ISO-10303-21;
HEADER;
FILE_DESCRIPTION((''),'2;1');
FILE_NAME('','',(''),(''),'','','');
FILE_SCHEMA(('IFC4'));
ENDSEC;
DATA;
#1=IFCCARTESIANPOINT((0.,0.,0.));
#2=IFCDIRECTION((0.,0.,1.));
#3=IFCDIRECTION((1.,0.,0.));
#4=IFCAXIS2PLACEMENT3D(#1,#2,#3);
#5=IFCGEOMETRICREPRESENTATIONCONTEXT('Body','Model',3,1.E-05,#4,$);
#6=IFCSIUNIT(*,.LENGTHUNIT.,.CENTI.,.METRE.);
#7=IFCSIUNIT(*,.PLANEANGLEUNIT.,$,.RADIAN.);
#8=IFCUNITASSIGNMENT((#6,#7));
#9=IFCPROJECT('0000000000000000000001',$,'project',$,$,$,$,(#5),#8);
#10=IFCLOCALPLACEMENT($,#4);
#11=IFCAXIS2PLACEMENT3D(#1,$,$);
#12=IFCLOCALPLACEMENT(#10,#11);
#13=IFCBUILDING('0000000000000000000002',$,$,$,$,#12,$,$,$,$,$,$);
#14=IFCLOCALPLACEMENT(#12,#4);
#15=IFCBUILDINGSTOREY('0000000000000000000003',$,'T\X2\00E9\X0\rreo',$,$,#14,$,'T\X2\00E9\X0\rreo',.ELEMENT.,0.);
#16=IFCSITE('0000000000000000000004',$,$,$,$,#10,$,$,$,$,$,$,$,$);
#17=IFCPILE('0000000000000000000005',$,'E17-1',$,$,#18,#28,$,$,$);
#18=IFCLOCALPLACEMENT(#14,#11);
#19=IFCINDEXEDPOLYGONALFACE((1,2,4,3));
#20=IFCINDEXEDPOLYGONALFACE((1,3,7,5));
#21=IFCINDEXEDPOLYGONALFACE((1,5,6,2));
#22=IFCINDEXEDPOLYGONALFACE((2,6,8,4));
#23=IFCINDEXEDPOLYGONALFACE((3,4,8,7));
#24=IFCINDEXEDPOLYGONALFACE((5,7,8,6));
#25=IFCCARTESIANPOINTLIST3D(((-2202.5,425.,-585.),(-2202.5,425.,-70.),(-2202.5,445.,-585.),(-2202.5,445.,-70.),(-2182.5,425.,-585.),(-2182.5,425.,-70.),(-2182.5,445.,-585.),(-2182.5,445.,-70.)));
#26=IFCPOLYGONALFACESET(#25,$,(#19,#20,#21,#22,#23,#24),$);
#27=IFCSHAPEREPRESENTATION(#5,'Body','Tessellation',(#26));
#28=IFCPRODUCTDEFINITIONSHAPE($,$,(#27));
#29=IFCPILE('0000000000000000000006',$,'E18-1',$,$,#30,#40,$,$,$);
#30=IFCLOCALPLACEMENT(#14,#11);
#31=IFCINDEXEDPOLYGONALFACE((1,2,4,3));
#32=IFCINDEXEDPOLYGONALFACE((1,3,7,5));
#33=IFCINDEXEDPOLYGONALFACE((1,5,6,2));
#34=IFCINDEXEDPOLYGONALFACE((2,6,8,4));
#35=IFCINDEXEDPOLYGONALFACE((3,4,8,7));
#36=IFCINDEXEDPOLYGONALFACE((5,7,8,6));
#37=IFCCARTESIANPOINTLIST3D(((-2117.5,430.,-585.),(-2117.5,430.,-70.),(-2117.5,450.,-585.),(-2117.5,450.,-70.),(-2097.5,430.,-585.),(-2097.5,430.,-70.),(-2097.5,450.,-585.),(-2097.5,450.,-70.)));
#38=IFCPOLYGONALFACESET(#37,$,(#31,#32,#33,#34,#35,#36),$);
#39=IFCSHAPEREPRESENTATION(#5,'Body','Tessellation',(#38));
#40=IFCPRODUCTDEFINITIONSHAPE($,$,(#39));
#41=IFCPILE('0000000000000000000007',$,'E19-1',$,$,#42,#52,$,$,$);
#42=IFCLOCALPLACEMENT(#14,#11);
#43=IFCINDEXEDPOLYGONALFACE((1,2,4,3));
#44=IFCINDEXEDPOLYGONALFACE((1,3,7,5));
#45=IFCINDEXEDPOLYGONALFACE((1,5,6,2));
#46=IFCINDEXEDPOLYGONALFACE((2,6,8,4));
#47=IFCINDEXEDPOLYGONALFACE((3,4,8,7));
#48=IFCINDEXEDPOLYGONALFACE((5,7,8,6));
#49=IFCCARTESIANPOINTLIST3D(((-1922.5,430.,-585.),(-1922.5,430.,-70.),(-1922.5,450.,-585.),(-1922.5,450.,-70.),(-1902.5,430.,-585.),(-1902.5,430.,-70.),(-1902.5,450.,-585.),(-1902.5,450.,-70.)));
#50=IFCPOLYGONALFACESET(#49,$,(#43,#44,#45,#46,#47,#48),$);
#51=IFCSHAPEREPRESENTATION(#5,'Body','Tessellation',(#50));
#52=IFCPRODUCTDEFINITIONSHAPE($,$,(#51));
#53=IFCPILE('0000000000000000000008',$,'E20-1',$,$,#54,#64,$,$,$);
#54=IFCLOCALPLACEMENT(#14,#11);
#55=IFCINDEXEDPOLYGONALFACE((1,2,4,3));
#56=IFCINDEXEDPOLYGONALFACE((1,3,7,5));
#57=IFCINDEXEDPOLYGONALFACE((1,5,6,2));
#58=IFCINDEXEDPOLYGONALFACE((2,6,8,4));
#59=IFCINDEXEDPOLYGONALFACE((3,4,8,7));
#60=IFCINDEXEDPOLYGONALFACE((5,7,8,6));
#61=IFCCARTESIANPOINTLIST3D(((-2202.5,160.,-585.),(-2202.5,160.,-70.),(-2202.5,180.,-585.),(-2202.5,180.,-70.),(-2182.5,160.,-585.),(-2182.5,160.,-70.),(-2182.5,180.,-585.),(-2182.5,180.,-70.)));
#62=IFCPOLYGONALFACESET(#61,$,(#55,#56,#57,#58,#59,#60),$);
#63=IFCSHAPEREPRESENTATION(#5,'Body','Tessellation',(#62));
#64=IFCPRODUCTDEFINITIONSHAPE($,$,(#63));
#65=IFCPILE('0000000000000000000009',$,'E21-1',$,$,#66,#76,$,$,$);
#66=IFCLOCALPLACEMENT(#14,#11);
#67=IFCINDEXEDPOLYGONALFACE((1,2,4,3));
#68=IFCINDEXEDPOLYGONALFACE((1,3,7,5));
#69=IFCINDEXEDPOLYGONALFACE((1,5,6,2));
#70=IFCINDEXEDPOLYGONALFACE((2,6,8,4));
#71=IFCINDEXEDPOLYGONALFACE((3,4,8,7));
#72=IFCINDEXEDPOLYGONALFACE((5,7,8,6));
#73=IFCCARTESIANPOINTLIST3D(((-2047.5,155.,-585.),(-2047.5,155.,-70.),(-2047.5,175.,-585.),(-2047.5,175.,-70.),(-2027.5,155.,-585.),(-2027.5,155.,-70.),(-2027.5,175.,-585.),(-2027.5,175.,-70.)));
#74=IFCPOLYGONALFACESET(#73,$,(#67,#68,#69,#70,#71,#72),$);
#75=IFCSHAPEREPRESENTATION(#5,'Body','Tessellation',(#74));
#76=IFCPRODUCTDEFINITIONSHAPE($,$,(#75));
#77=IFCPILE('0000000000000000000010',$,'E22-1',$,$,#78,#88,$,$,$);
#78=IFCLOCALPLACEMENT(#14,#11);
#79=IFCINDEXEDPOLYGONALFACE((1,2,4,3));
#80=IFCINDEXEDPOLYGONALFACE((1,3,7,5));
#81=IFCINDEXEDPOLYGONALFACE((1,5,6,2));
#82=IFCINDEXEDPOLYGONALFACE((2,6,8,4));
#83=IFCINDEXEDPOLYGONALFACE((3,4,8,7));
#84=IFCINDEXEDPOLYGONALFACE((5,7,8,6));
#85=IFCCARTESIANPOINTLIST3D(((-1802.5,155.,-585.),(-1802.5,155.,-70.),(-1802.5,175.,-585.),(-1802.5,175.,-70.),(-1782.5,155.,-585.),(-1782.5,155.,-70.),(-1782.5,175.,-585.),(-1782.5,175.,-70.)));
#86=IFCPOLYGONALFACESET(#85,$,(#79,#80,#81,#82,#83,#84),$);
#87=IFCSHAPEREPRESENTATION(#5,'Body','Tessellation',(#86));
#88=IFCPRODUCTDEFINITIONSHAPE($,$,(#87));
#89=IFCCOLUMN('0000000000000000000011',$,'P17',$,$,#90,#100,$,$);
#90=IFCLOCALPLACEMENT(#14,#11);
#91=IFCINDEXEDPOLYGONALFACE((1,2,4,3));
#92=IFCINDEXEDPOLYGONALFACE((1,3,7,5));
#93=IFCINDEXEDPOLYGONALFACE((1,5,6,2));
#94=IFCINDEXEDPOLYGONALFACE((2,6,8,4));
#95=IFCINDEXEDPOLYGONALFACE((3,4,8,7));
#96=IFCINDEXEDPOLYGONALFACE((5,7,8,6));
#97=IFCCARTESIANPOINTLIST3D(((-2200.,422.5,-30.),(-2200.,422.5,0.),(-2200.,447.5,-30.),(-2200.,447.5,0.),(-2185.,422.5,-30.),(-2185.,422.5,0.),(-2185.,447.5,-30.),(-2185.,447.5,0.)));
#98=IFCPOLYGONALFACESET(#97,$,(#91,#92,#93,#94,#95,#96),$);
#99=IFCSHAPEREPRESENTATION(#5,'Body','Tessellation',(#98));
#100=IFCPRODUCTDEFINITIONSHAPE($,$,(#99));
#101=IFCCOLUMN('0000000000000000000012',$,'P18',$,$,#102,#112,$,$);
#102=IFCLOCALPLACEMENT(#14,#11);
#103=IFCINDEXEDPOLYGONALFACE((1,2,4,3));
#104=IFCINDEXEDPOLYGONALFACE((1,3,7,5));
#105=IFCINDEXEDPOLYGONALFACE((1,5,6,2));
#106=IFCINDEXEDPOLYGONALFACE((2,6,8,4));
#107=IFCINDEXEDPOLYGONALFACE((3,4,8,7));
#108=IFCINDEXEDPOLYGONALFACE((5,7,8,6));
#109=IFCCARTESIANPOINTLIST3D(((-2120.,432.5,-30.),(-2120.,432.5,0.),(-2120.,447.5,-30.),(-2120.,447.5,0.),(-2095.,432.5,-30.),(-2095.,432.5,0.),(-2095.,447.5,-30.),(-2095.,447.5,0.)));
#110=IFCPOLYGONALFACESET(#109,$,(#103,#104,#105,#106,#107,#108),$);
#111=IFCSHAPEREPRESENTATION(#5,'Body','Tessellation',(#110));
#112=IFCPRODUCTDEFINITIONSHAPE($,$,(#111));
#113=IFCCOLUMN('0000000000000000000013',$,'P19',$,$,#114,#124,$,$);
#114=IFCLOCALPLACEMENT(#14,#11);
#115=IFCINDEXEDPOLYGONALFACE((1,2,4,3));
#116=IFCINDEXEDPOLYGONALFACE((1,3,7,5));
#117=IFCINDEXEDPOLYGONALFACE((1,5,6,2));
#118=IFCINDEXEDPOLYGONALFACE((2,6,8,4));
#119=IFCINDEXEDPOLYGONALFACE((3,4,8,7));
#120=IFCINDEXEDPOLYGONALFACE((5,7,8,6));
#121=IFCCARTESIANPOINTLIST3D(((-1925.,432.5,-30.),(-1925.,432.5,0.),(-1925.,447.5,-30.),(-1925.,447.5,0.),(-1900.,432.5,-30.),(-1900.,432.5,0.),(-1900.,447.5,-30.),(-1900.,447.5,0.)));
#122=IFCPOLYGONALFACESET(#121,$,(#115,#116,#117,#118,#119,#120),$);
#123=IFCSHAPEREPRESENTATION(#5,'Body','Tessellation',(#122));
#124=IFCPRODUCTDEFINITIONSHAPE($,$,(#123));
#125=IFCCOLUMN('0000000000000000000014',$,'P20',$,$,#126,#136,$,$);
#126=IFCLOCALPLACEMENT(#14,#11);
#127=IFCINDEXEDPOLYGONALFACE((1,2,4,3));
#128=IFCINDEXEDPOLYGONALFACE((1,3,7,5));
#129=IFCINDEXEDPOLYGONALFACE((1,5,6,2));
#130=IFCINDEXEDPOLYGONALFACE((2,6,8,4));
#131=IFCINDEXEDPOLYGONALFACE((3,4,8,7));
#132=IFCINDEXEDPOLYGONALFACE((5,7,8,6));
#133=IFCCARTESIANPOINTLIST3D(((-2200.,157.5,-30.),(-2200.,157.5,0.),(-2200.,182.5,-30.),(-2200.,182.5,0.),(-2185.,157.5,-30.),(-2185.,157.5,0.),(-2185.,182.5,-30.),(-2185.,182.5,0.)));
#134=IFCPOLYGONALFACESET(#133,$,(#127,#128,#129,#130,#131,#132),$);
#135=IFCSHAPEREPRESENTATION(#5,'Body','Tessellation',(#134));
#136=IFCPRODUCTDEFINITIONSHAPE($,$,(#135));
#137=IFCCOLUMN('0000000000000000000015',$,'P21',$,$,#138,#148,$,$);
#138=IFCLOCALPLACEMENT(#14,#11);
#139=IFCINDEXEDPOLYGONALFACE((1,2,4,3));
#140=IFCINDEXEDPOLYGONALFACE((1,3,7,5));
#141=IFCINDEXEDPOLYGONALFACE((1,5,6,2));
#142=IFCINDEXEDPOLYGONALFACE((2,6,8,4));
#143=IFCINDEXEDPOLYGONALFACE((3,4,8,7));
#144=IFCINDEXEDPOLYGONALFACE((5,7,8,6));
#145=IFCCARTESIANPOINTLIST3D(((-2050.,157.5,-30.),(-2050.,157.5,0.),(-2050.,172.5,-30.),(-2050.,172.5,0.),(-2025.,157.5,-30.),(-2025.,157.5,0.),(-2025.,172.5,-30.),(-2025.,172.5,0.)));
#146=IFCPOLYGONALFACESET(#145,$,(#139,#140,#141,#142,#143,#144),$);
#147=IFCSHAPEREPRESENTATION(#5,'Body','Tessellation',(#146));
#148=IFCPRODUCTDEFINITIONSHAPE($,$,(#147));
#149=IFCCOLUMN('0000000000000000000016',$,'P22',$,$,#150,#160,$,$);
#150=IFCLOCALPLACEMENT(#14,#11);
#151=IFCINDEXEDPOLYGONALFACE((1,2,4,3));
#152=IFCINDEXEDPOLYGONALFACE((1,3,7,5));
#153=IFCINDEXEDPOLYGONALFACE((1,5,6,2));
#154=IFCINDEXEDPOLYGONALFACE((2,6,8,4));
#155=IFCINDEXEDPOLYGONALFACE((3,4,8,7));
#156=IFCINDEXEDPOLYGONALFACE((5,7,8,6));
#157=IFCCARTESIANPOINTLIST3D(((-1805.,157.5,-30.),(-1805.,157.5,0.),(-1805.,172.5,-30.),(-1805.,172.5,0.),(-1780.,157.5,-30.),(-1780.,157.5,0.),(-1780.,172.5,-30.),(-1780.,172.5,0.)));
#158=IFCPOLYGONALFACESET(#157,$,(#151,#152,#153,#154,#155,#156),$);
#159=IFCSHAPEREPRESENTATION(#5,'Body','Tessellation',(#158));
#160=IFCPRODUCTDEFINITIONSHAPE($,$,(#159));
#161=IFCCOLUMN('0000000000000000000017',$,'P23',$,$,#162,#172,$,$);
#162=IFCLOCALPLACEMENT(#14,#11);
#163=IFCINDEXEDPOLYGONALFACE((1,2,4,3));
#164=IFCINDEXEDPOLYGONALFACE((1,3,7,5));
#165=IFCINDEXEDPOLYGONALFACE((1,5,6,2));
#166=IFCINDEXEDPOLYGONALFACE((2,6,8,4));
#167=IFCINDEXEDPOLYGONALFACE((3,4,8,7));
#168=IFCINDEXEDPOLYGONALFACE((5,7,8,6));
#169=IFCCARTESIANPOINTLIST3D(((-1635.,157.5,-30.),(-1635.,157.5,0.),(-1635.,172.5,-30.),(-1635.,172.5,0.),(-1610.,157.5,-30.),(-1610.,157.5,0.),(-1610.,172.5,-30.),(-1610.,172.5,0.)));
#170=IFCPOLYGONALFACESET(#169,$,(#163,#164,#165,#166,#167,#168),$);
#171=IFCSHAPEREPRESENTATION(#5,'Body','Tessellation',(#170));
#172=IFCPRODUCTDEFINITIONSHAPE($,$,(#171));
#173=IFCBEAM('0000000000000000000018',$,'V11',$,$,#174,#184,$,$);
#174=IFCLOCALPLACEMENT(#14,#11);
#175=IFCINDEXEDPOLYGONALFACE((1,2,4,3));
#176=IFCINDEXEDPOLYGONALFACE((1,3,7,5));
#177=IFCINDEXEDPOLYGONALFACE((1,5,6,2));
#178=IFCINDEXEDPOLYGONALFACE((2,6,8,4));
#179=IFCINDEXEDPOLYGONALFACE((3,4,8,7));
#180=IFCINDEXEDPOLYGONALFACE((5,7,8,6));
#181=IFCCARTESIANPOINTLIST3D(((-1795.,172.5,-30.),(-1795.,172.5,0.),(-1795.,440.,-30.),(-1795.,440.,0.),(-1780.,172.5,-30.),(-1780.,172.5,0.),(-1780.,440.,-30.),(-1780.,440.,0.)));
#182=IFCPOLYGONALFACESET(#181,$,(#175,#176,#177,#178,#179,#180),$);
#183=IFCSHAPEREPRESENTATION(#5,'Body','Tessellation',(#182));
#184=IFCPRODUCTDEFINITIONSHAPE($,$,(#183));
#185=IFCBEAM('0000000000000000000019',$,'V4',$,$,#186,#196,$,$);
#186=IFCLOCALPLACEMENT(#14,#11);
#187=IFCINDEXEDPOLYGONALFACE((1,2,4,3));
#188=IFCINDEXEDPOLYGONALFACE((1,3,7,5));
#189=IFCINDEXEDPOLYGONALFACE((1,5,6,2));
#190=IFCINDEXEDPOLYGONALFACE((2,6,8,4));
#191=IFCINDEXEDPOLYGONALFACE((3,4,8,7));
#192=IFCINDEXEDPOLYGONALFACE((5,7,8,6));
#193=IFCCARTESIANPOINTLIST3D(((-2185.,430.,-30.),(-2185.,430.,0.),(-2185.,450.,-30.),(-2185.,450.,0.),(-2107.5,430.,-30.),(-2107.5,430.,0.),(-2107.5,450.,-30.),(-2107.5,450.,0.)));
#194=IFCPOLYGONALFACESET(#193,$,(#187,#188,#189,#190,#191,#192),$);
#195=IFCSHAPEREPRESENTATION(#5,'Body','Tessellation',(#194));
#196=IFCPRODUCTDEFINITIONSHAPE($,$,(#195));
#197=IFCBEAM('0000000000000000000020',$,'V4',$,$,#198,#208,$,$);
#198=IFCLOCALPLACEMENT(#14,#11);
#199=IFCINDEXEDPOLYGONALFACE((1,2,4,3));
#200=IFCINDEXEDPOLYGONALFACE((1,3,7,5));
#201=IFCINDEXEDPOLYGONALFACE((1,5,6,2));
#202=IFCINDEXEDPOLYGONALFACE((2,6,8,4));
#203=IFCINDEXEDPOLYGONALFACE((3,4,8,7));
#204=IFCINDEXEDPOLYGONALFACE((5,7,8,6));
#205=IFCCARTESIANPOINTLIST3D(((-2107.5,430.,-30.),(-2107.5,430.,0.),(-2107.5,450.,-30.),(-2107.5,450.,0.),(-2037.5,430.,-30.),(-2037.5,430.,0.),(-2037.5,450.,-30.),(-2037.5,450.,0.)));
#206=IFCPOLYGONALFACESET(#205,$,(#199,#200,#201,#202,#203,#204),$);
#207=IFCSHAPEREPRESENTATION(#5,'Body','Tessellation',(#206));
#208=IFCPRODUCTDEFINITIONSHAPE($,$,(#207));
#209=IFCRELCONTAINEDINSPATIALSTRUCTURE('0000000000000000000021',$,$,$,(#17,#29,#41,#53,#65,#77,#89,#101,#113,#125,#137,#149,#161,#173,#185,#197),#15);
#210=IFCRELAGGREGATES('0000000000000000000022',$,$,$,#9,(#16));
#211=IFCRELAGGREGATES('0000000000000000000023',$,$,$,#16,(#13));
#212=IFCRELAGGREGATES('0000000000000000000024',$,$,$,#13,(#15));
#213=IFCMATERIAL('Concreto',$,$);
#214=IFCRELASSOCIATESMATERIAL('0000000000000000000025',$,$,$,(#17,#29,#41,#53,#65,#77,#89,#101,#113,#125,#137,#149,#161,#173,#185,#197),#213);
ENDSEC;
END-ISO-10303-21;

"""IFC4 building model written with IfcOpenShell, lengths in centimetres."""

from ifc_helpers import new_model, si_unit, frame, origin, origin_with_axes, origin_2d_with_axis, place, context, project, spatial, rectangle, extrude, material, element, save


model = new_model("IFC4")

# Units and contexts
model_context = context("Model", 3, precision=1e-05, world=origin_with_axes(), identifier="Body")
ifc_project = project(units=[si_unit("LENGTHUNIT", "METRE", prefix="CENTI"), si_unit("PLANEANGLEUNIT", "RADIAN")], contexts=[model_context])

# Site, building, storey
site_placement = place(None, origin_with_axes())
site = spatial("IfcSite", under=ifc_project, at=site_placement)
building_placement = place(site_placement, origin())
building = spatial("IfcBuilding", under=site, at=building_placement)
storey_placement = place(building_placement, origin_with_axes())
storey = spatial("IfcBuildingStorey", under=building, at=storey_placement, Name="Térreo", LongName="Térreo", CompositionType="ELEMENT", Elevation=0.0)

# Piles
ifc_material = material(Name="Concreto")
pile_1_placement = place(storey_placement, frame((-2192.5, 435.0, -70.0), z_axis=(0.0, 0.0, 1.0), x_axis=(1.0, 0.0, 0.0)))
element("IfcPile", 1, at=pile_1_placement, inside=storey, material=ifc_material, Name="E17-1", context=model_context, shape_type="SweptSolid", body=[
    extrude(rectangle(XDim=20.0, YDim=20.0, at=origin_2d_with_axis()), frame((0.0, 0.0, -515.0), z_axis=(0.0, 0.0, 1.0), x_axis=(-1.0, 0.0, 0.0)), (0.0, 0.0, 1.0), 515.0),
])
for number, where, z_axis, x_axis, name in (
    (2, (-2107.5, 440.0, -70.0), (0.0, 0.0, 1.0), (1.0, 0.0, 0.0), "E18-1"),
    (3, (-1912.5, 440.0, -70.0), (0.0, 0.0, 1.0), (1.0, 0.0, 0.0), "E19-1"),
):
    element("IfcPile", number, at=place(storey_placement, frame(where, z_axis=z_axis, x_axis=x_axis)), inside=storey, material=ifc_material, Name=name, context=model_context, shape_type="SweptSolid", body=[
        extrude(rectangle(XDim=20.0, YDim=20.0, at=origin_2d_with_axis()), frame((0.0, 0.0, -515.0), z_axis=(0.0, 0.0, 1.0), x_axis=(0.0, 1.0, 0.0)), (0.0, 0.0, 1.0), 515.0),
    ])
pile_2_placement = place(storey_placement, frame((-2192.5, 170.0, -70.0), z_axis=(0.0, 0.0, 1.0), x_axis=(1.0, 0.0, 0.0)))
element("IfcPile", 4, at=pile_2_placement, inside=storey, material=ifc_material, Name="E20-1", context=model_context, shape_type="SweptSolid", body=[
    extrude(rectangle(XDim=20.0, YDim=20.0, at=origin_2d_with_axis()), frame((0.0, 0.0, -515.0), z_axis=(0.0, 0.0, 1.0), x_axis=(1.0, 0.0, 0.0)), (0.0, 0.0, 1.0), 515.0),
])
pile_3_placement = place(storey_placement, frame((-2037.5, 165.0, -70.0), z_axis=(0.0, 0.0, 1.0), x_axis=(1.0, 0.0, 0.0)))
element("IfcPile", 5, at=pile_3_placement, inside=storey, material=ifc_material, Name="E21-1", context=model_context, shape_type="SweptSolid", body=[
    extrude(rectangle(XDim=20.0, YDim=20.0, at=origin_2d_with_axis()), frame((0.0, 0.0, -515.0), z_axis=(0.0, 0.0, 1.0), x_axis=(0.0, 1.0, 0.0)), (0.0, 0.0, 1.0), 515.0),
])
pile_4_placement = place(storey_placement, frame((-1792.5, 165.0, -70.0), z_axis=(0.0, 0.0, 1.0), x_axis=(1.0, 0.0, 0.0)))
element("IfcPile", 6, at=pile_4_placement, inside=storey, material=ifc_material, Name="E22-1", context=model_context, shape_type="SweptSolid", body=[
    extrude(rectangle(XDim=20.0, YDim=20.0, at=origin_2d_with_axis()), frame((0.0, 0.0, -515.0), z_axis=(0.0, 0.0, 1.0), x_axis=(0.0, -1.0, 0.0)), (0.0, 0.0, 1.0), 515.0),
])

# Columns
column_1_placement = place(storey_placement, frame((-2192.5, 435.0, 0.0), z_axis=(0.0, 0.0, 1.0), x_axis=(1.0, 0.0, 0.0)))
element("IfcColumn", 7, at=column_1_placement, inside=storey, material=ifc_material, Name="P17", context=model_context, shape_type="SolidModel", body=[
    extrude(rectangle(XDim=15.0, YDim=25.0, at=origin_2d_with_axis()), frame((0.0, 0.0, -30.0), z_axis=(0.0, 0.0, 1.0), x_axis=(-1.0, 0.0, 0.0)), (0.0, 0.0, 1.0), 30.0),
])
for number, where, z_axis, x_axis, name in (
    (8, (-2107.5, 440.0, 0.0), (0.0, 0.0, 1.0), (1.0, 0.0, 0.0), "P18"),
    (9, (-1912.5, 440.0, 0.0), (0.0, 0.0, 1.0), (1.0, 0.0, 0.0), "P19"),
):
    element("IfcColumn", number, at=place(storey_placement, frame(where, z_axis=z_axis, x_axis=x_axis)), inside=storey, material=ifc_material, Name=name, context=model_context, shape_type="SolidModel", body=[
        extrude(rectangle(XDim=15.0, YDim=25.0, at=origin_2d_with_axis()), frame((0.0, 0.0, -30.0), z_axis=(0.0, 0.0, 1.0), x_axis=(0.0, 1.0, 0.0)), (0.0, 0.0, 1.0), 30.0),
    ])
column_2_placement = place(storey_placement, frame((-2192.5, 170.0, 0.0), z_axis=(0.0, 0.0, 1.0), x_axis=(1.0, 0.0, 0.0)))
element("IfcColumn", 10, at=column_2_placement, inside=storey, material=ifc_material, Name="P20", context=model_context, shape_type="SolidModel", body=[
    extrude(rectangle(XDim=15.0, YDim=25.0, at=origin_2d_with_axis()), frame((0.0, 0.0, -30.0), z_axis=(0.0, 0.0, 1.0), x_axis=(1.0, 0.0, 0.0)), (0.0, 0.0, 1.0), 30.0),
])
column_3_placement = place(storey_placement, frame((-2037.5, 165.0, 0.0), z_axis=(0.0, 0.0, 1.0), x_axis=(1.0, 0.0, 0.0)))
element("IfcColumn", 11, at=column_3_placement, inside=storey, material=ifc_material, Name="P21", context=model_context, shape_type="SolidModel", body=[
    extrude(rectangle(XDim=15.0, YDim=25.0, at=origin_2d_with_axis()), frame((0.0, 0.0, -30.0), z_axis=(0.0, 0.0, 1.0), x_axis=(0.0, 1.0, 0.0)), (0.0, 0.0, 1.0), 30.0),
])
column_4_placement = place(storey_placement, frame((-1792.5, 165.0, 0.0), z_axis=(0.0, 0.0, 1.0), x_axis=(1.0, 0.0, 0.0)))
element("IfcColumn", 12, at=column_4_placement, inside=storey, material=ifc_material, Name="P22", context=model_context, shape_type="SolidModel", body=[
    extrude(rectangle(XDim=15.0, YDim=25.0, at=origin_2d_with_axis()), frame((0.0, 0.0, -30.0), z_axis=(0.0, 0.0, 1.0), x_axis=(0.0, -1.0, 0.0)), (0.0, 0.0, 1.0), 30.0),
])
column_5_placement = place(storey_placement, frame((-1622.5, 165.0, 0.0), z_axis=(0.0, 0.0, 1.0), x_axis=(1.0, 0.0, 0.0)))
element("IfcColumn", 13, at=column_5_placement, inside=storey, material=ifc_material, Name="P23", context=model_context, shape_type="SolidModel", body=[
    extrude(rectangle(XDim=15.0, YDim=25.0, at=origin_2d_with_axis()), frame((0.0, 0.0, -30.0), z_axis=(0.0, 0.0, 1.0), x_axis=(0.0, 1.0, 0.0)), (0.0, 0.0, 1.0), 30.0),
])

# Beams
beam_1_placement = place(storey_placement, frame((-1787.5, 306.25, 0.0), z_axis=(0.0, 0.0, 1.0), x_axis=(1.0, 0.0, 0.0)))
element("IfcBeam", 14, at=beam_1_placement, inside=storey, material=ifc_material, Name="V11", context=model_context, shape_type="SolidModel", body=[
    extrude(rectangle(XDim=15.0, YDim=30.0, at=origin_2d_with_axis()), frame((0.0, -133.75, -15.0), z_axis=(0.0, 1.0, 0.0), x_axis=(-1.0, 0.0, 0.0)), (0.0, 0.0, 1.0), 267.5),
])
beam_2_placement = place(storey_placement, frame((-2146.25, 440.0, 0.0), z_axis=(0.0, 0.0, 1.0), x_axis=(1.0, 0.0, 0.0)))
element("IfcBeam", 15, at=beam_2_placement, inside=storey, material=ifc_material, Name="V4", context=model_context, shape_type="SolidModel", body=[
    extrude(rectangle(XDim=20.0, YDim=30.0, at=origin_2d_with_axis()), frame((-38.75, 0.0, -15.0), z_axis=(1.0, 0.0, 0.0), x_axis=(0.0, -1.0, 0.0)), (0.0, 0.0, 1.0), 77.5),
])
beam_3_placement = place(storey_placement, frame((-2072.5, 440.0, 0.0), z_axis=(0.0, 0.0, 1.0), x_axis=(1.0, 0.0, 0.0)))
element("IfcBeam", 16, at=beam_3_placement, inside=storey, material=ifc_material, Name="V4", context=model_context, shape_type="SolidModel", body=[
    extrude(rectangle(XDim=20.0, YDim=30.0, at=origin_2d_with_axis()), frame((-35.0, 0.0, -15.0), z_axis=(1.0, 0.0, 0.0), x_axis=(0.0, -1.0, 0.0)), (0.0, 0.0, 1.0), 70.0),
])

save(model, "model.ifc")
